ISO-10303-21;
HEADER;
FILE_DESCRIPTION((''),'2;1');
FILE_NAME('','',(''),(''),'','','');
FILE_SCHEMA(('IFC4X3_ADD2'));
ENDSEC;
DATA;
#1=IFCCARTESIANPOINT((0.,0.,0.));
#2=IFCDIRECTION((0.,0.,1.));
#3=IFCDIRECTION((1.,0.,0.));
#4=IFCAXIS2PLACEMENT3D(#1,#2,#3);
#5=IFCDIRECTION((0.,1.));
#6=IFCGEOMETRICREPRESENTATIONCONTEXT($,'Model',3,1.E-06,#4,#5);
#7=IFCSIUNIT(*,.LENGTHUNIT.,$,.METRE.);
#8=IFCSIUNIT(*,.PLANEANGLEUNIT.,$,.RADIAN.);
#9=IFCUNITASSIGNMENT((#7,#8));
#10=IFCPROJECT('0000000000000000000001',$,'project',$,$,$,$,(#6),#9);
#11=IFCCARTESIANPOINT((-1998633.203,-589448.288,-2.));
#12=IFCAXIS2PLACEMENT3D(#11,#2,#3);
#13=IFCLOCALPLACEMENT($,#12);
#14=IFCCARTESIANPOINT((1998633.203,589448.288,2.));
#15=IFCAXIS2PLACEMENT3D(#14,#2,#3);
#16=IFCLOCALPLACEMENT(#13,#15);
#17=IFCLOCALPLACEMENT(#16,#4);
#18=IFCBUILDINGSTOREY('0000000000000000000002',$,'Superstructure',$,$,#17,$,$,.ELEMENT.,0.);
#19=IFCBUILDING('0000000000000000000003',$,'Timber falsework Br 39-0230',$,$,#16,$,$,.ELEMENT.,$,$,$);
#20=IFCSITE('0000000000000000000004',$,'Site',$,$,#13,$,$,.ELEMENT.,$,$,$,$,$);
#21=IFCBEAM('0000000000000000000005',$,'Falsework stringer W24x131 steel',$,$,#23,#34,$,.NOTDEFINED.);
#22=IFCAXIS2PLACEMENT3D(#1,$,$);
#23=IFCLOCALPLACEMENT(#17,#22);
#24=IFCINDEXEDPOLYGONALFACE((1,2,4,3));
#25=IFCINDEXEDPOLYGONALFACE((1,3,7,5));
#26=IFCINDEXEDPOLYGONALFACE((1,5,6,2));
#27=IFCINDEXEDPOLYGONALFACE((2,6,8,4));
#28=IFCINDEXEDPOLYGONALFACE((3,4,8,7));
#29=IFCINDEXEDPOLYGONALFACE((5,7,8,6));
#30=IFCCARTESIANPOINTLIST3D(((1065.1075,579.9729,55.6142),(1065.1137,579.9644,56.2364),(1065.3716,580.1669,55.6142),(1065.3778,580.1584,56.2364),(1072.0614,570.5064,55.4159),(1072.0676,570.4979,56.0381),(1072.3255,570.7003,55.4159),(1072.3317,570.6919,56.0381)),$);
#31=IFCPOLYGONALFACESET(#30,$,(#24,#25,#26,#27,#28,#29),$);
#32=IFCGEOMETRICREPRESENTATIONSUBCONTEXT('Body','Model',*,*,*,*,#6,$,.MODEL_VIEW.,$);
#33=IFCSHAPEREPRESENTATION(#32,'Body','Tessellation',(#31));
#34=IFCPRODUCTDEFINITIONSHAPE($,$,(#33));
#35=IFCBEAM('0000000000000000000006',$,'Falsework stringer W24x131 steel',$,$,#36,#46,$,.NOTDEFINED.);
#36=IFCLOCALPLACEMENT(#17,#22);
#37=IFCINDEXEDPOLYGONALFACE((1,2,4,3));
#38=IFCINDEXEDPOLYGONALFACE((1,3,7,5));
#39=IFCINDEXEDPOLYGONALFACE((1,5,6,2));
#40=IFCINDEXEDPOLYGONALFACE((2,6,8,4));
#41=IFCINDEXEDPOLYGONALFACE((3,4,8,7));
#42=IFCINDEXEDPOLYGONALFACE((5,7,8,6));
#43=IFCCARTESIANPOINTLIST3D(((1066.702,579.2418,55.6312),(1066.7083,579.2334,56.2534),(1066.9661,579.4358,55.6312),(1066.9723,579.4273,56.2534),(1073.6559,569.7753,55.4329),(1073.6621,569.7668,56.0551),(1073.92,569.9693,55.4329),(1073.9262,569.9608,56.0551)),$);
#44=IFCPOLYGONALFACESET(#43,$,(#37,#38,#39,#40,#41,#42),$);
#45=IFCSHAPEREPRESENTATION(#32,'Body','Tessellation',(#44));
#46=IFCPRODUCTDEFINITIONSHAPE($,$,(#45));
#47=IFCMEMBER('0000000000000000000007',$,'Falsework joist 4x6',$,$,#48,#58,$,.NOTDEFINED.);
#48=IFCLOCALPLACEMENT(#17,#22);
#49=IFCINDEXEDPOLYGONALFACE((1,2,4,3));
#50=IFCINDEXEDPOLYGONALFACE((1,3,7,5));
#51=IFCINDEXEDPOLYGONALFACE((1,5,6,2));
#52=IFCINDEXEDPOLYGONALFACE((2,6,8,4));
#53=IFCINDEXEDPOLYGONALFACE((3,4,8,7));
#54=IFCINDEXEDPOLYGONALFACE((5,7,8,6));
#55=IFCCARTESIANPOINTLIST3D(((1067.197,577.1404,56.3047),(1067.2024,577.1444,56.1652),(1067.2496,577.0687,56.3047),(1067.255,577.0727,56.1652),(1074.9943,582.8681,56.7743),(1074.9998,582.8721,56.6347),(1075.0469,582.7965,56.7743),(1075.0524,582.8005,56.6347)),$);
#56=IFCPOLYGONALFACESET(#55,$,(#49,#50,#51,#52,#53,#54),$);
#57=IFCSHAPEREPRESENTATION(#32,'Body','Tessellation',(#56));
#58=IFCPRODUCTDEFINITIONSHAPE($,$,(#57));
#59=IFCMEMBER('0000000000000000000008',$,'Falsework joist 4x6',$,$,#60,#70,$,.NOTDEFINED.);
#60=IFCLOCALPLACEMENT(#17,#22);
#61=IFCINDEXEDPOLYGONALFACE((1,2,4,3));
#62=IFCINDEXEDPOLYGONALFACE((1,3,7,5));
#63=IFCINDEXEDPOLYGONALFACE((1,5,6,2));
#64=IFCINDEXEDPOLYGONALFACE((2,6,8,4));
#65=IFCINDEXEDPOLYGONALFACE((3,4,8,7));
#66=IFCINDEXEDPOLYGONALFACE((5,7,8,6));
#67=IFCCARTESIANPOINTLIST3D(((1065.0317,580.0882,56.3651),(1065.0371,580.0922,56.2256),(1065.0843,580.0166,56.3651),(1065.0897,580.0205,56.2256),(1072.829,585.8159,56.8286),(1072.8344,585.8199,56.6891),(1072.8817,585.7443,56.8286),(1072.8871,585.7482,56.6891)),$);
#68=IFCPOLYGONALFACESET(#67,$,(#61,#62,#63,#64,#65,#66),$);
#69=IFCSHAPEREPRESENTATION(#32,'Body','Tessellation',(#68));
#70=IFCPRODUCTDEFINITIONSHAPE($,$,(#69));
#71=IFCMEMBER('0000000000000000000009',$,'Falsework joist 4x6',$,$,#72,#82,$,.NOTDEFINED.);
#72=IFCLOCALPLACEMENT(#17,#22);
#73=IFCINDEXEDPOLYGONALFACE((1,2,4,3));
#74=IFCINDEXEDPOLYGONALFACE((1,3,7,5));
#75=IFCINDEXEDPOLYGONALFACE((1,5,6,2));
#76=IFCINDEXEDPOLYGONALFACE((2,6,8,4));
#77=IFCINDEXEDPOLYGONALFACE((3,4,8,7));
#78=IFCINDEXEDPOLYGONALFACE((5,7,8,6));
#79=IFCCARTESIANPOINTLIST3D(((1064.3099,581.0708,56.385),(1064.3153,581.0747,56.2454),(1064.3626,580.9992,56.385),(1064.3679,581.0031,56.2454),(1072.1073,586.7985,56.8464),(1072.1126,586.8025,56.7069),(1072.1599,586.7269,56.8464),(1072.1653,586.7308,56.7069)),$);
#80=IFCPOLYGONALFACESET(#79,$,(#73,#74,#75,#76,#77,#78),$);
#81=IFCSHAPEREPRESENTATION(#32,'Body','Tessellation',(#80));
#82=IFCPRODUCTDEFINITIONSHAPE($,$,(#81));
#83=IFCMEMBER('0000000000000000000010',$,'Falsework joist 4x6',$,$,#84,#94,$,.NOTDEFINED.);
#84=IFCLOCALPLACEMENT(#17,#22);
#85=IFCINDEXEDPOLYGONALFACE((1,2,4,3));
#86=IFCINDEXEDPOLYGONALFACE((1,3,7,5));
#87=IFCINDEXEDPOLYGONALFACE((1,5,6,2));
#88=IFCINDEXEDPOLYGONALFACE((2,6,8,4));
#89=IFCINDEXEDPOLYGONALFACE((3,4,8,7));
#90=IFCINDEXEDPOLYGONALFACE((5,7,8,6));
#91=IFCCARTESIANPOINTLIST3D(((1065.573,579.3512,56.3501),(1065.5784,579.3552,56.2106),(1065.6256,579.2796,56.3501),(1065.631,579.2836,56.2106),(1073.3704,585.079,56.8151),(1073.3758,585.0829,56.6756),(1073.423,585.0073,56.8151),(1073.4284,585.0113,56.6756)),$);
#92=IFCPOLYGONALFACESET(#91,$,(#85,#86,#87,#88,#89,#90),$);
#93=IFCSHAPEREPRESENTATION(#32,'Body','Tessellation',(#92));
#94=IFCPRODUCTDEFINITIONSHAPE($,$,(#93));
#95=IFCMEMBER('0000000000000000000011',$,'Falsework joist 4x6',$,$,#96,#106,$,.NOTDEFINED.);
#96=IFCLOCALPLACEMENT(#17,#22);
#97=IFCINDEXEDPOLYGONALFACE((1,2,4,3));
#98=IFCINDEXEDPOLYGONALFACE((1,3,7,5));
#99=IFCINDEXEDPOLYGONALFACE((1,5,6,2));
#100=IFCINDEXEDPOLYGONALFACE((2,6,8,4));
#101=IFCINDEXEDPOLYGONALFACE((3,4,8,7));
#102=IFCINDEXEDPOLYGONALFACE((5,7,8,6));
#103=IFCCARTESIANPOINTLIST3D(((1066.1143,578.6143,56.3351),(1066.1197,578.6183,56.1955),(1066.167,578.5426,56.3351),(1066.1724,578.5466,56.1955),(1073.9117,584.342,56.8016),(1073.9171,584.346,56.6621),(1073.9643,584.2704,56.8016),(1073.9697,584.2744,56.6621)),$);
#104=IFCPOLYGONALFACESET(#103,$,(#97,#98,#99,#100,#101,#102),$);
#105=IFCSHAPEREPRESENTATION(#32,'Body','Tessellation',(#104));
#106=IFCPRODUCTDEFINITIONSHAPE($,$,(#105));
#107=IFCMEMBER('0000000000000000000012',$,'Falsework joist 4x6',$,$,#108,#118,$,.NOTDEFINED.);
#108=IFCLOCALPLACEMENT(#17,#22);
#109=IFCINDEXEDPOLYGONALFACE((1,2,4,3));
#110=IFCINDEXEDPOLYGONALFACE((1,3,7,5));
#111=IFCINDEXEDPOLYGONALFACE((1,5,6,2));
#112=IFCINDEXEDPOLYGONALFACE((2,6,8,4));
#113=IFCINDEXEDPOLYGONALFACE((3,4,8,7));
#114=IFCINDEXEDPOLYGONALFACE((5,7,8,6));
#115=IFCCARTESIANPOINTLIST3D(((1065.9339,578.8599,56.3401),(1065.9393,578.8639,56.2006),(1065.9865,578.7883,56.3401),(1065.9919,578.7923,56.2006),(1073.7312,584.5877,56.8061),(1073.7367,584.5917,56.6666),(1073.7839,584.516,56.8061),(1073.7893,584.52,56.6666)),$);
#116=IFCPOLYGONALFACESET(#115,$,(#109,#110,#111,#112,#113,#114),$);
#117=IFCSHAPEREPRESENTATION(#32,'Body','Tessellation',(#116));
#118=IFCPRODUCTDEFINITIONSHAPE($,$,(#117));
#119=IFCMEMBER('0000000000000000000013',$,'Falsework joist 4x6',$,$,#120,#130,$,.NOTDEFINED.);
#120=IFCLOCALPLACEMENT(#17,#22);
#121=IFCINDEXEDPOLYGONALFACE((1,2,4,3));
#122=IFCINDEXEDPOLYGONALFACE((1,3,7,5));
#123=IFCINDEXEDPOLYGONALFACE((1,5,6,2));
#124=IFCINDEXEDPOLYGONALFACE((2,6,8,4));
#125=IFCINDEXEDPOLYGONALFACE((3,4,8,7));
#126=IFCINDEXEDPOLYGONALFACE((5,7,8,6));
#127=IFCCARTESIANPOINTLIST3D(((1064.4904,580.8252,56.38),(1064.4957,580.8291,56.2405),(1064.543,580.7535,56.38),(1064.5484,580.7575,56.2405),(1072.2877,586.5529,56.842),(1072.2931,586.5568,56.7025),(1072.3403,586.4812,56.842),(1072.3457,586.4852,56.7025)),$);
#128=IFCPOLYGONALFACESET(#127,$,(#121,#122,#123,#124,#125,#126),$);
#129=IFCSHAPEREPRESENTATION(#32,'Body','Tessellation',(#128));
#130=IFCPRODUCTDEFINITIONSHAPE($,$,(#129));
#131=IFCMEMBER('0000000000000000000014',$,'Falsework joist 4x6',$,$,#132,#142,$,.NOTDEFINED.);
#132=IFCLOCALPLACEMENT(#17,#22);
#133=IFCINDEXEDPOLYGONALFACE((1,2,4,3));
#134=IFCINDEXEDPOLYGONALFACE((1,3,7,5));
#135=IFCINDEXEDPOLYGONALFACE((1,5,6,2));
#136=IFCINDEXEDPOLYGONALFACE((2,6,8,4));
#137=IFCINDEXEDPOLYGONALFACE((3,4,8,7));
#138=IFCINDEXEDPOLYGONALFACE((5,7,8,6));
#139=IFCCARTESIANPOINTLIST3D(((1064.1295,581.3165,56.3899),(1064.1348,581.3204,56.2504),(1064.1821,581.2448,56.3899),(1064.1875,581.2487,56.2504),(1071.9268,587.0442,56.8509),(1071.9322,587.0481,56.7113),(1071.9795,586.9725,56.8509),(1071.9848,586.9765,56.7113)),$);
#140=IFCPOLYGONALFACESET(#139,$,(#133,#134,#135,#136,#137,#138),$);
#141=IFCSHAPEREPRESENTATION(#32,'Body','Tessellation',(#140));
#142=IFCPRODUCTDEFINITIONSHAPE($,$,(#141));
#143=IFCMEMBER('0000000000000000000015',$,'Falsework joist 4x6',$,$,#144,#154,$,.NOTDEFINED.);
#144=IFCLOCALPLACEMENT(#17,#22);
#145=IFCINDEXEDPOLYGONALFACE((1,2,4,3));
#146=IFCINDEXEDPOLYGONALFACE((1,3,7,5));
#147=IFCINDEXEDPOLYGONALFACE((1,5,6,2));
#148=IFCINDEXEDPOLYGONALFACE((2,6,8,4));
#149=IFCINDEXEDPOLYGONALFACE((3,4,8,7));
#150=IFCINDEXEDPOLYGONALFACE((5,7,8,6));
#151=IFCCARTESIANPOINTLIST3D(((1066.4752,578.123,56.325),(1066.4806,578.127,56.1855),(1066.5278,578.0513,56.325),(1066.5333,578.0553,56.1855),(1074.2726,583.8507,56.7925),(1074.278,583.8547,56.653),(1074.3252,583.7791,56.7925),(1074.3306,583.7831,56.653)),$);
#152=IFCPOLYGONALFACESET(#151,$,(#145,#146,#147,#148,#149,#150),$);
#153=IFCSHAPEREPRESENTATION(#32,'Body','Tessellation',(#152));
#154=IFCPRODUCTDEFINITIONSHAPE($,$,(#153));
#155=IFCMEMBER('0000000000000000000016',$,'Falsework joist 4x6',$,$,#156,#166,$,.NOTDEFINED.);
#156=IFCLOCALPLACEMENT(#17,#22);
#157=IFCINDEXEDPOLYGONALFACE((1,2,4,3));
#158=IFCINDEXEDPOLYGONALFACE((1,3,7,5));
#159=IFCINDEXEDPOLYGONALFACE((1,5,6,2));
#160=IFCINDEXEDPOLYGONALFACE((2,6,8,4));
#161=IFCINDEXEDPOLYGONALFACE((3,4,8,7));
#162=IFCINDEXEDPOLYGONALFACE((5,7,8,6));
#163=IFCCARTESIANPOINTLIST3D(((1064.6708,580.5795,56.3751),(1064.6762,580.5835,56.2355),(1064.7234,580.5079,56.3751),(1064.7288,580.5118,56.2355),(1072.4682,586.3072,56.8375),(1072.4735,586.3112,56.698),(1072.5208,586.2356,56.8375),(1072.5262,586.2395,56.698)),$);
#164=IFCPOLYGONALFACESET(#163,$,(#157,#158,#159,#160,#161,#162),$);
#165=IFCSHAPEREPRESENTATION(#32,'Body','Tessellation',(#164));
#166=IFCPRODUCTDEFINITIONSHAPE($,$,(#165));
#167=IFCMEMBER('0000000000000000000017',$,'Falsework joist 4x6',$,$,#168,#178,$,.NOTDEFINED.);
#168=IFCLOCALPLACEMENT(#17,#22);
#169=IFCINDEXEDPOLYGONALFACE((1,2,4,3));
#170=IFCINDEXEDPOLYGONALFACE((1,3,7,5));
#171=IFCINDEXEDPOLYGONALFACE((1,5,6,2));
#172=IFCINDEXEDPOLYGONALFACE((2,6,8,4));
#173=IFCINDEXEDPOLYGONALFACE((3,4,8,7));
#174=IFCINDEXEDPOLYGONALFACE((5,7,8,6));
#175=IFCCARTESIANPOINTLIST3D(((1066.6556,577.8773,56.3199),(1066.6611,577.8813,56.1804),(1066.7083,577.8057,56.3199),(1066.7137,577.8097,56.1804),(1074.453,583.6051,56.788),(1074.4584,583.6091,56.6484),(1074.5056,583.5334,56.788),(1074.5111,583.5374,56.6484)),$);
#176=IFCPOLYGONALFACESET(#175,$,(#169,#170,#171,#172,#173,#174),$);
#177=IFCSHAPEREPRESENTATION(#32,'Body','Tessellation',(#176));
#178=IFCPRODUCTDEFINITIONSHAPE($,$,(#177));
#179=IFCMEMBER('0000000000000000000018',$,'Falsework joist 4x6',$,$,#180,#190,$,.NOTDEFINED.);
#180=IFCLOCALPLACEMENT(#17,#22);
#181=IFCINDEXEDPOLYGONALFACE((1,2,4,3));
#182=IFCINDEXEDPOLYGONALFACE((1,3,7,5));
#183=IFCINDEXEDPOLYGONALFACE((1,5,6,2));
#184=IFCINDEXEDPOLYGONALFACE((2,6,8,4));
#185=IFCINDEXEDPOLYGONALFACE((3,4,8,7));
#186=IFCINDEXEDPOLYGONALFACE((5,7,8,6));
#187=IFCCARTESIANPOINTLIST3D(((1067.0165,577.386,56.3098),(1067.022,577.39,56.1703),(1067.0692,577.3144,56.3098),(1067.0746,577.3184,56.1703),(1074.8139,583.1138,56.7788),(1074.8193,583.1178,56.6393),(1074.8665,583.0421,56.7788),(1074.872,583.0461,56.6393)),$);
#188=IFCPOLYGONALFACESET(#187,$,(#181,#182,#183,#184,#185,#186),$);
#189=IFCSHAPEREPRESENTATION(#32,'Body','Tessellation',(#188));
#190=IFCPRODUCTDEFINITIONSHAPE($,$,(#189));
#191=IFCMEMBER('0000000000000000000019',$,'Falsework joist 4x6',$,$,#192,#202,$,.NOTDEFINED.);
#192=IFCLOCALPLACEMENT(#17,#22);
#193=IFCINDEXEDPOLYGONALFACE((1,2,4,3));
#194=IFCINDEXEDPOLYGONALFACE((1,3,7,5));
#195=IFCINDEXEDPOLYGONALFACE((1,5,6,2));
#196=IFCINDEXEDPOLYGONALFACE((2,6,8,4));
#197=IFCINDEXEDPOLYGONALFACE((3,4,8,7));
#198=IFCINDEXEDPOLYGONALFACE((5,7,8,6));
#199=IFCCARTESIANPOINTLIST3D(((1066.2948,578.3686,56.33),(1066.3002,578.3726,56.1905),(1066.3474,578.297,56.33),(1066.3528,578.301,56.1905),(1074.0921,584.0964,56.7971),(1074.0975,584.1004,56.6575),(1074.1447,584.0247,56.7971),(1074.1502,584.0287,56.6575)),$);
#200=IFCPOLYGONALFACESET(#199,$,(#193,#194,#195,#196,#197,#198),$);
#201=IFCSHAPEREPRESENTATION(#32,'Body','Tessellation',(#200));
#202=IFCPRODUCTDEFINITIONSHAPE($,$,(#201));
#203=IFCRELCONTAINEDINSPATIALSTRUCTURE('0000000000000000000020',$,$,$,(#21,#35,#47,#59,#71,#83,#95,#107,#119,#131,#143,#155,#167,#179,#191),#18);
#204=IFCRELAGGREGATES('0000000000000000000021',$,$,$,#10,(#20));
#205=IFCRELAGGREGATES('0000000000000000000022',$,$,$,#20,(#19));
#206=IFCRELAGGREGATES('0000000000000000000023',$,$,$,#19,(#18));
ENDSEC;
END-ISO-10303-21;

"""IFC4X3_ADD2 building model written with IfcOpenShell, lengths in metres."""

from ifc_helpers import new_model, si_unit, direction, frame, frame_2d, origin, origin_with_axes, place, context, subcontext, project, spatial, rectangle, extrude, element, save


model = new_model("IFC4X3_ADD2")

# Units and contexts
model_context = context("Model", 3, precision=1e-06, world=origin_with_axes(), true_north=direction((0.0, 1.0)))
body_context = subcontext(model_context, "Body", "Model", "MODEL_VIEW")
ifc_project = project(units=[si_unit("LENGTHUNIT", "METRE"), si_unit("PLANEANGLEUNIT", "RADIAN")], contexts=[model_context])

# Site, building, storey
site_placement = place(None, frame((-1998633.203, -589448.288, -2.0), z_axis=(0.0, 0.0, 1.0), x_axis=(1.0, 0.0, 0.0)))
site = spatial("IfcSite", under=ifc_project, at=site_placement, Name="Site", CompositionType="ELEMENT")
building_placement = place(site_placement, frame((1998633.203, 589448.288, 2.0), z_axis=(0.0, 0.0, 1.0), x_axis=(1.0, 0.0, 0.0)))
building = spatial("IfcBuilding", under=site, at=building_placement, Name="Timber falsework Br 39-0230", CompositionType="ELEMENT")
storey_placement = place(building_placement, origin_with_axes())
storey = spatial("IfcBuildingStorey", under=building, at=storey_placement, Name="Superstructure", CompositionType="ELEMENT", Elevation=0.0)

# Beams
for number, where, z_axis, x_axis, name in (
    (1, (1065.2396, 580.0699, 55.6142), (0.591929, -0.805813, -0.016879), (0.805928, 0.592013, 0.0), "Falsework stringer W24x131 steel"),
    (2, (1066.8341, 579.3388, 55.6312), (0.591929, -0.805813, -0.016879), (0.805928, 0.592013, 0.0), "Falsework stringer W24x131 steel"),
):
    element("IfcBeam", number, at=place(storey_placement, frame(where, z_axis=z_axis, x_axis=x_axis)), inside=storey, Name=name, PredefinedType="NOTDEFINED", context=body_context, shape_type="SweptSolid", body=[
        extrude(rectangle(XDim=0.3277, YDim=0.6223, at=frame_2d((0.0, 0.3111))), origin(), (0.0, 0.0, 1.0), 11.7478),
    ])

# Members
member_1_placement = place(storey_placement, frame((1067.2287, 577.1086, 56.1652), z_axis=(0.804981, 0.591317, 0.048475), x_axis=(-0.592013, 0.805928, 0.0)))
element("IfcMember", 3, at=member_1_placement, inside=storey, Name="Falsework joist 4x6", PredefinedType="NOTDEFINED", context=body_context, shape_type="SweptSolid", body=[
    extrude(rectangle(XDim=0.0889, YDim=0.1397, at=frame_2d((0.0, 0.0698))), origin(), (0.0, 0.0, 1.0), 9.6864),
])
member_2_placement = place(storey_placement, frame((1065.0634, 580.0563, 56.2256), z_axis=(0.805005, 0.591335, 0.047851), x_axis=(-0.592013, 0.805928, 0.0)))
element("IfcMember", 4, at=member_2_placement, inside=storey, Name="Falsework joist 4x6", PredefinedType="NOTDEFINED", context=body_context, shape_type="SweptSolid", body=[
    extrude(rectangle(XDim=0.0889, YDim=0.1397, at=frame_2d((0.0, 0.0698))), origin(), (0.0, 0.0, 1.0), 9.6861),
])
member_3_placement = place(storey_placement, frame((1064.3416, 581.0389, 56.2454), z_axis=(0.805013, 0.591341, 0.047644), x_axis=(-0.592013, 0.805928, 0.0)))
element("IfcMember", 5, at=member_3_placement, inside=storey, Name="Falsework joist 4x6", PredefinedType="NOTDEFINED", context=body_context, shape_type="SweptSolid", body=[
    extrude(rectangle(XDim=0.0889, YDim=0.1397, at=frame_2d((0.0, 0.0698))), origin(), (0.0, 0.0, 1.0), 9.686),
])
member_4_placement = place(storey_placement, frame((1065.6047, 579.3194, 56.2106), z_axis=(0.804999, 0.591331, 0.048007), x_axis=(-0.592013, 0.805928, 0.0)))
element("IfcMember", 6, at=member_4_placement, inside=storey, Name="Falsework joist 4x6", PredefinedType="NOTDEFINED", context=body_context, shape_type="SweptSolid", body=[
    extrude(rectangle(XDim=0.0889, YDim=0.1397, at=frame_2d((0.0, 0.0698))), origin(), (0.0, 0.0, 1.0), 9.6862),
])
member_5_placement = place(storey_placement, frame((1066.1461, 578.5825, 56.1955), z_axis=(0.804993, 0.591326, 0.048163), x_axis=(-0.592013, 0.805928, 0.0)))
element("IfcMember", 7, at=member_5_placement, inside=storey, Name="Falsework joist 4x6", PredefinedType="NOTDEFINED", context=body_context, shape_type="SweptSolid", body=[
    extrude(rectangle(XDim=0.0889, YDim=0.1397, at=frame_2d((0.0, 0.0698))), origin(), (0.0, 0.0, 1.0), 9.6862),
])
member_6_placement = place(storey_placement, frame((1065.9656, 578.8281, 56.2006), z_axis=(0.804995, 0.591328, 0.048111), x_axis=(-0.592013, 0.805928, 0.0)))
element("IfcMember", 8, at=member_6_placement, inside=storey, Name="Falsework joist 4x6", PredefinedType="NOTDEFINED", context=body_context, shape_type="SweptSolid", body=[
    extrude(rectangle(XDim=0.0889, YDim=0.1397, at=frame_2d((0.0, 0.0698))), origin(), (0.0, 0.0, 1.0), 9.6862),
])
member_7_placement = place(storey_placement, frame((1064.522, 580.7933, 56.2405), z_axis=(0.805011, 0.591339, 0.047696), x_axis=(-0.592013, 0.805928, 0.0)))
element("IfcMember", 9, at=member_7_placement, inside=storey, Name="Falsework joist 4x6", PredefinedType="NOTDEFINED", context=body_context, shape_type="SweptSolid", body=[
    extrude(rectangle(XDim=0.0889, YDim=0.1397, at=frame_2d((0.0, 0.0698))), origin(), (0.0, 0.0, 1.0), 9.686),
])
member_8_placement = place(storey_placement, frame((1064.1612, 581.2846, 56.2504), z_axis=(0.805015, 0.591342, 0.047592), x_axis=(-0.592013, 0.805928, 0.0)))
element("IfcMember", 10, at=member_8_placement, inside=storey, Name="Falsework joist 4x6", PredefinedType="NOTDEFINED", context=body_context, shape_type="SweptSolid", body=[
    extrude(rectangle(XDim=0.0889, YDim=0.1397, at=frame_2d((0.0, 0.0698))), origin(), (0.0, 0.0, 1.0), 9.686),
])
member_9_placement = place(storey_placement, frame((1066.507, 578.0912, 56.1855), z_axis=(0.804989, 0.591323, 0.048267), x_axis=(-0.592013, 0.805928, 0.0)))
element("IfcMember", 11, at=member_9_placement, inside=storey, Name="Falsework joist 4x6", PredefinedType="NOTDEFINED", context=body_context, shape_type="SweptSolid", body=[
    extrude(rectangle(XDim=0.0889, YDim=0.1397, at=frame_2d((0.0, 0.0698))), origin(), (0.0, 0.0, 1.0), 9.6863),
])
member_10_placement = place(storey_placement, frame((1064.7025, 580.5476, 56.2355), z_axis=(0.805009, 0.591338, 0.047748), x_axis=(-0.592013, 0.805928, 0.0)))
element("IfcMember", 12, at=member_10_placement, inside=storey, Name="Falsework joist 4x6", PredefinedType="NOTDEFINED", context=body_context, shape_type="SweptSolid", body=[
    extrude(rectangle(XDim=0.0889, YDim=0.1397, at=frame_2d((0.0, 0.0698))), origin(), (0.0, 0.0, 1.0), 9.686),
])
member_11_placement = place(storey_placement, frame((1066.6874, 577.8455, 56.1804), z_axis=(0.804987, 0.591322, 0.048319), x_axis=(-0.592013, 0.805928, 0.0)))
element("IfcMember", 13, at=member_11_placement, inside=storey, Name="Falsework joist 4x6", PredefinedType="NOTDEFINED", context=body_context, shape_type="SweptSolid", body=[
    extrude(rectangle(XDim=0.0889, YDim=0.1397, at=frame_2d((0.0, 0.0698))), origin(), (0.0, 0.0, 1.0), 9.6863),
])
member_12_placement = place(storey_placement, frame((1067.0483, 577.3542, 56.1703), z_axis=(0.804983, 0.591319, 0.048423), x_axis=(-0.592013, 0.805928, 0.0)))
element("IfcMember", 14, at=member_12_placement, inside=storey, Name="Falsework joist 4x6", PredefinedType="NOTDEFINED", context=body_context, shape_type="SweptSolid", body=[
    extrude(rectangle(XDim=0.0889, YDim=0.1397, at=frame_2d((0.0, 0.0698))), origin(), (0.0, 0.0, 1.0), 9.6864),
])
member_13_placement = place(storey_placement, frame((1066.3265, 578.3368, 56.1905), z_axis=(0.804991, 0.591325, 0.048215), x_axis=(-0.592013, 0.805928, 0.0)))
element("IfcMember", 15, at=member_13_placement, inside=storey, Name="Falsework joist 4x6", PredefinedType="NOTDEFINED", context=body_context, shape_type="SweptSolid", body=[
    extrude(rectangle(XDim=0.0889, YDim=0.1397, at=frame_2d((0.0, 0.0698))), origin(), (0.0, 0.0, 1.0), 9.6863),
])

save(model, "model.ifc")
